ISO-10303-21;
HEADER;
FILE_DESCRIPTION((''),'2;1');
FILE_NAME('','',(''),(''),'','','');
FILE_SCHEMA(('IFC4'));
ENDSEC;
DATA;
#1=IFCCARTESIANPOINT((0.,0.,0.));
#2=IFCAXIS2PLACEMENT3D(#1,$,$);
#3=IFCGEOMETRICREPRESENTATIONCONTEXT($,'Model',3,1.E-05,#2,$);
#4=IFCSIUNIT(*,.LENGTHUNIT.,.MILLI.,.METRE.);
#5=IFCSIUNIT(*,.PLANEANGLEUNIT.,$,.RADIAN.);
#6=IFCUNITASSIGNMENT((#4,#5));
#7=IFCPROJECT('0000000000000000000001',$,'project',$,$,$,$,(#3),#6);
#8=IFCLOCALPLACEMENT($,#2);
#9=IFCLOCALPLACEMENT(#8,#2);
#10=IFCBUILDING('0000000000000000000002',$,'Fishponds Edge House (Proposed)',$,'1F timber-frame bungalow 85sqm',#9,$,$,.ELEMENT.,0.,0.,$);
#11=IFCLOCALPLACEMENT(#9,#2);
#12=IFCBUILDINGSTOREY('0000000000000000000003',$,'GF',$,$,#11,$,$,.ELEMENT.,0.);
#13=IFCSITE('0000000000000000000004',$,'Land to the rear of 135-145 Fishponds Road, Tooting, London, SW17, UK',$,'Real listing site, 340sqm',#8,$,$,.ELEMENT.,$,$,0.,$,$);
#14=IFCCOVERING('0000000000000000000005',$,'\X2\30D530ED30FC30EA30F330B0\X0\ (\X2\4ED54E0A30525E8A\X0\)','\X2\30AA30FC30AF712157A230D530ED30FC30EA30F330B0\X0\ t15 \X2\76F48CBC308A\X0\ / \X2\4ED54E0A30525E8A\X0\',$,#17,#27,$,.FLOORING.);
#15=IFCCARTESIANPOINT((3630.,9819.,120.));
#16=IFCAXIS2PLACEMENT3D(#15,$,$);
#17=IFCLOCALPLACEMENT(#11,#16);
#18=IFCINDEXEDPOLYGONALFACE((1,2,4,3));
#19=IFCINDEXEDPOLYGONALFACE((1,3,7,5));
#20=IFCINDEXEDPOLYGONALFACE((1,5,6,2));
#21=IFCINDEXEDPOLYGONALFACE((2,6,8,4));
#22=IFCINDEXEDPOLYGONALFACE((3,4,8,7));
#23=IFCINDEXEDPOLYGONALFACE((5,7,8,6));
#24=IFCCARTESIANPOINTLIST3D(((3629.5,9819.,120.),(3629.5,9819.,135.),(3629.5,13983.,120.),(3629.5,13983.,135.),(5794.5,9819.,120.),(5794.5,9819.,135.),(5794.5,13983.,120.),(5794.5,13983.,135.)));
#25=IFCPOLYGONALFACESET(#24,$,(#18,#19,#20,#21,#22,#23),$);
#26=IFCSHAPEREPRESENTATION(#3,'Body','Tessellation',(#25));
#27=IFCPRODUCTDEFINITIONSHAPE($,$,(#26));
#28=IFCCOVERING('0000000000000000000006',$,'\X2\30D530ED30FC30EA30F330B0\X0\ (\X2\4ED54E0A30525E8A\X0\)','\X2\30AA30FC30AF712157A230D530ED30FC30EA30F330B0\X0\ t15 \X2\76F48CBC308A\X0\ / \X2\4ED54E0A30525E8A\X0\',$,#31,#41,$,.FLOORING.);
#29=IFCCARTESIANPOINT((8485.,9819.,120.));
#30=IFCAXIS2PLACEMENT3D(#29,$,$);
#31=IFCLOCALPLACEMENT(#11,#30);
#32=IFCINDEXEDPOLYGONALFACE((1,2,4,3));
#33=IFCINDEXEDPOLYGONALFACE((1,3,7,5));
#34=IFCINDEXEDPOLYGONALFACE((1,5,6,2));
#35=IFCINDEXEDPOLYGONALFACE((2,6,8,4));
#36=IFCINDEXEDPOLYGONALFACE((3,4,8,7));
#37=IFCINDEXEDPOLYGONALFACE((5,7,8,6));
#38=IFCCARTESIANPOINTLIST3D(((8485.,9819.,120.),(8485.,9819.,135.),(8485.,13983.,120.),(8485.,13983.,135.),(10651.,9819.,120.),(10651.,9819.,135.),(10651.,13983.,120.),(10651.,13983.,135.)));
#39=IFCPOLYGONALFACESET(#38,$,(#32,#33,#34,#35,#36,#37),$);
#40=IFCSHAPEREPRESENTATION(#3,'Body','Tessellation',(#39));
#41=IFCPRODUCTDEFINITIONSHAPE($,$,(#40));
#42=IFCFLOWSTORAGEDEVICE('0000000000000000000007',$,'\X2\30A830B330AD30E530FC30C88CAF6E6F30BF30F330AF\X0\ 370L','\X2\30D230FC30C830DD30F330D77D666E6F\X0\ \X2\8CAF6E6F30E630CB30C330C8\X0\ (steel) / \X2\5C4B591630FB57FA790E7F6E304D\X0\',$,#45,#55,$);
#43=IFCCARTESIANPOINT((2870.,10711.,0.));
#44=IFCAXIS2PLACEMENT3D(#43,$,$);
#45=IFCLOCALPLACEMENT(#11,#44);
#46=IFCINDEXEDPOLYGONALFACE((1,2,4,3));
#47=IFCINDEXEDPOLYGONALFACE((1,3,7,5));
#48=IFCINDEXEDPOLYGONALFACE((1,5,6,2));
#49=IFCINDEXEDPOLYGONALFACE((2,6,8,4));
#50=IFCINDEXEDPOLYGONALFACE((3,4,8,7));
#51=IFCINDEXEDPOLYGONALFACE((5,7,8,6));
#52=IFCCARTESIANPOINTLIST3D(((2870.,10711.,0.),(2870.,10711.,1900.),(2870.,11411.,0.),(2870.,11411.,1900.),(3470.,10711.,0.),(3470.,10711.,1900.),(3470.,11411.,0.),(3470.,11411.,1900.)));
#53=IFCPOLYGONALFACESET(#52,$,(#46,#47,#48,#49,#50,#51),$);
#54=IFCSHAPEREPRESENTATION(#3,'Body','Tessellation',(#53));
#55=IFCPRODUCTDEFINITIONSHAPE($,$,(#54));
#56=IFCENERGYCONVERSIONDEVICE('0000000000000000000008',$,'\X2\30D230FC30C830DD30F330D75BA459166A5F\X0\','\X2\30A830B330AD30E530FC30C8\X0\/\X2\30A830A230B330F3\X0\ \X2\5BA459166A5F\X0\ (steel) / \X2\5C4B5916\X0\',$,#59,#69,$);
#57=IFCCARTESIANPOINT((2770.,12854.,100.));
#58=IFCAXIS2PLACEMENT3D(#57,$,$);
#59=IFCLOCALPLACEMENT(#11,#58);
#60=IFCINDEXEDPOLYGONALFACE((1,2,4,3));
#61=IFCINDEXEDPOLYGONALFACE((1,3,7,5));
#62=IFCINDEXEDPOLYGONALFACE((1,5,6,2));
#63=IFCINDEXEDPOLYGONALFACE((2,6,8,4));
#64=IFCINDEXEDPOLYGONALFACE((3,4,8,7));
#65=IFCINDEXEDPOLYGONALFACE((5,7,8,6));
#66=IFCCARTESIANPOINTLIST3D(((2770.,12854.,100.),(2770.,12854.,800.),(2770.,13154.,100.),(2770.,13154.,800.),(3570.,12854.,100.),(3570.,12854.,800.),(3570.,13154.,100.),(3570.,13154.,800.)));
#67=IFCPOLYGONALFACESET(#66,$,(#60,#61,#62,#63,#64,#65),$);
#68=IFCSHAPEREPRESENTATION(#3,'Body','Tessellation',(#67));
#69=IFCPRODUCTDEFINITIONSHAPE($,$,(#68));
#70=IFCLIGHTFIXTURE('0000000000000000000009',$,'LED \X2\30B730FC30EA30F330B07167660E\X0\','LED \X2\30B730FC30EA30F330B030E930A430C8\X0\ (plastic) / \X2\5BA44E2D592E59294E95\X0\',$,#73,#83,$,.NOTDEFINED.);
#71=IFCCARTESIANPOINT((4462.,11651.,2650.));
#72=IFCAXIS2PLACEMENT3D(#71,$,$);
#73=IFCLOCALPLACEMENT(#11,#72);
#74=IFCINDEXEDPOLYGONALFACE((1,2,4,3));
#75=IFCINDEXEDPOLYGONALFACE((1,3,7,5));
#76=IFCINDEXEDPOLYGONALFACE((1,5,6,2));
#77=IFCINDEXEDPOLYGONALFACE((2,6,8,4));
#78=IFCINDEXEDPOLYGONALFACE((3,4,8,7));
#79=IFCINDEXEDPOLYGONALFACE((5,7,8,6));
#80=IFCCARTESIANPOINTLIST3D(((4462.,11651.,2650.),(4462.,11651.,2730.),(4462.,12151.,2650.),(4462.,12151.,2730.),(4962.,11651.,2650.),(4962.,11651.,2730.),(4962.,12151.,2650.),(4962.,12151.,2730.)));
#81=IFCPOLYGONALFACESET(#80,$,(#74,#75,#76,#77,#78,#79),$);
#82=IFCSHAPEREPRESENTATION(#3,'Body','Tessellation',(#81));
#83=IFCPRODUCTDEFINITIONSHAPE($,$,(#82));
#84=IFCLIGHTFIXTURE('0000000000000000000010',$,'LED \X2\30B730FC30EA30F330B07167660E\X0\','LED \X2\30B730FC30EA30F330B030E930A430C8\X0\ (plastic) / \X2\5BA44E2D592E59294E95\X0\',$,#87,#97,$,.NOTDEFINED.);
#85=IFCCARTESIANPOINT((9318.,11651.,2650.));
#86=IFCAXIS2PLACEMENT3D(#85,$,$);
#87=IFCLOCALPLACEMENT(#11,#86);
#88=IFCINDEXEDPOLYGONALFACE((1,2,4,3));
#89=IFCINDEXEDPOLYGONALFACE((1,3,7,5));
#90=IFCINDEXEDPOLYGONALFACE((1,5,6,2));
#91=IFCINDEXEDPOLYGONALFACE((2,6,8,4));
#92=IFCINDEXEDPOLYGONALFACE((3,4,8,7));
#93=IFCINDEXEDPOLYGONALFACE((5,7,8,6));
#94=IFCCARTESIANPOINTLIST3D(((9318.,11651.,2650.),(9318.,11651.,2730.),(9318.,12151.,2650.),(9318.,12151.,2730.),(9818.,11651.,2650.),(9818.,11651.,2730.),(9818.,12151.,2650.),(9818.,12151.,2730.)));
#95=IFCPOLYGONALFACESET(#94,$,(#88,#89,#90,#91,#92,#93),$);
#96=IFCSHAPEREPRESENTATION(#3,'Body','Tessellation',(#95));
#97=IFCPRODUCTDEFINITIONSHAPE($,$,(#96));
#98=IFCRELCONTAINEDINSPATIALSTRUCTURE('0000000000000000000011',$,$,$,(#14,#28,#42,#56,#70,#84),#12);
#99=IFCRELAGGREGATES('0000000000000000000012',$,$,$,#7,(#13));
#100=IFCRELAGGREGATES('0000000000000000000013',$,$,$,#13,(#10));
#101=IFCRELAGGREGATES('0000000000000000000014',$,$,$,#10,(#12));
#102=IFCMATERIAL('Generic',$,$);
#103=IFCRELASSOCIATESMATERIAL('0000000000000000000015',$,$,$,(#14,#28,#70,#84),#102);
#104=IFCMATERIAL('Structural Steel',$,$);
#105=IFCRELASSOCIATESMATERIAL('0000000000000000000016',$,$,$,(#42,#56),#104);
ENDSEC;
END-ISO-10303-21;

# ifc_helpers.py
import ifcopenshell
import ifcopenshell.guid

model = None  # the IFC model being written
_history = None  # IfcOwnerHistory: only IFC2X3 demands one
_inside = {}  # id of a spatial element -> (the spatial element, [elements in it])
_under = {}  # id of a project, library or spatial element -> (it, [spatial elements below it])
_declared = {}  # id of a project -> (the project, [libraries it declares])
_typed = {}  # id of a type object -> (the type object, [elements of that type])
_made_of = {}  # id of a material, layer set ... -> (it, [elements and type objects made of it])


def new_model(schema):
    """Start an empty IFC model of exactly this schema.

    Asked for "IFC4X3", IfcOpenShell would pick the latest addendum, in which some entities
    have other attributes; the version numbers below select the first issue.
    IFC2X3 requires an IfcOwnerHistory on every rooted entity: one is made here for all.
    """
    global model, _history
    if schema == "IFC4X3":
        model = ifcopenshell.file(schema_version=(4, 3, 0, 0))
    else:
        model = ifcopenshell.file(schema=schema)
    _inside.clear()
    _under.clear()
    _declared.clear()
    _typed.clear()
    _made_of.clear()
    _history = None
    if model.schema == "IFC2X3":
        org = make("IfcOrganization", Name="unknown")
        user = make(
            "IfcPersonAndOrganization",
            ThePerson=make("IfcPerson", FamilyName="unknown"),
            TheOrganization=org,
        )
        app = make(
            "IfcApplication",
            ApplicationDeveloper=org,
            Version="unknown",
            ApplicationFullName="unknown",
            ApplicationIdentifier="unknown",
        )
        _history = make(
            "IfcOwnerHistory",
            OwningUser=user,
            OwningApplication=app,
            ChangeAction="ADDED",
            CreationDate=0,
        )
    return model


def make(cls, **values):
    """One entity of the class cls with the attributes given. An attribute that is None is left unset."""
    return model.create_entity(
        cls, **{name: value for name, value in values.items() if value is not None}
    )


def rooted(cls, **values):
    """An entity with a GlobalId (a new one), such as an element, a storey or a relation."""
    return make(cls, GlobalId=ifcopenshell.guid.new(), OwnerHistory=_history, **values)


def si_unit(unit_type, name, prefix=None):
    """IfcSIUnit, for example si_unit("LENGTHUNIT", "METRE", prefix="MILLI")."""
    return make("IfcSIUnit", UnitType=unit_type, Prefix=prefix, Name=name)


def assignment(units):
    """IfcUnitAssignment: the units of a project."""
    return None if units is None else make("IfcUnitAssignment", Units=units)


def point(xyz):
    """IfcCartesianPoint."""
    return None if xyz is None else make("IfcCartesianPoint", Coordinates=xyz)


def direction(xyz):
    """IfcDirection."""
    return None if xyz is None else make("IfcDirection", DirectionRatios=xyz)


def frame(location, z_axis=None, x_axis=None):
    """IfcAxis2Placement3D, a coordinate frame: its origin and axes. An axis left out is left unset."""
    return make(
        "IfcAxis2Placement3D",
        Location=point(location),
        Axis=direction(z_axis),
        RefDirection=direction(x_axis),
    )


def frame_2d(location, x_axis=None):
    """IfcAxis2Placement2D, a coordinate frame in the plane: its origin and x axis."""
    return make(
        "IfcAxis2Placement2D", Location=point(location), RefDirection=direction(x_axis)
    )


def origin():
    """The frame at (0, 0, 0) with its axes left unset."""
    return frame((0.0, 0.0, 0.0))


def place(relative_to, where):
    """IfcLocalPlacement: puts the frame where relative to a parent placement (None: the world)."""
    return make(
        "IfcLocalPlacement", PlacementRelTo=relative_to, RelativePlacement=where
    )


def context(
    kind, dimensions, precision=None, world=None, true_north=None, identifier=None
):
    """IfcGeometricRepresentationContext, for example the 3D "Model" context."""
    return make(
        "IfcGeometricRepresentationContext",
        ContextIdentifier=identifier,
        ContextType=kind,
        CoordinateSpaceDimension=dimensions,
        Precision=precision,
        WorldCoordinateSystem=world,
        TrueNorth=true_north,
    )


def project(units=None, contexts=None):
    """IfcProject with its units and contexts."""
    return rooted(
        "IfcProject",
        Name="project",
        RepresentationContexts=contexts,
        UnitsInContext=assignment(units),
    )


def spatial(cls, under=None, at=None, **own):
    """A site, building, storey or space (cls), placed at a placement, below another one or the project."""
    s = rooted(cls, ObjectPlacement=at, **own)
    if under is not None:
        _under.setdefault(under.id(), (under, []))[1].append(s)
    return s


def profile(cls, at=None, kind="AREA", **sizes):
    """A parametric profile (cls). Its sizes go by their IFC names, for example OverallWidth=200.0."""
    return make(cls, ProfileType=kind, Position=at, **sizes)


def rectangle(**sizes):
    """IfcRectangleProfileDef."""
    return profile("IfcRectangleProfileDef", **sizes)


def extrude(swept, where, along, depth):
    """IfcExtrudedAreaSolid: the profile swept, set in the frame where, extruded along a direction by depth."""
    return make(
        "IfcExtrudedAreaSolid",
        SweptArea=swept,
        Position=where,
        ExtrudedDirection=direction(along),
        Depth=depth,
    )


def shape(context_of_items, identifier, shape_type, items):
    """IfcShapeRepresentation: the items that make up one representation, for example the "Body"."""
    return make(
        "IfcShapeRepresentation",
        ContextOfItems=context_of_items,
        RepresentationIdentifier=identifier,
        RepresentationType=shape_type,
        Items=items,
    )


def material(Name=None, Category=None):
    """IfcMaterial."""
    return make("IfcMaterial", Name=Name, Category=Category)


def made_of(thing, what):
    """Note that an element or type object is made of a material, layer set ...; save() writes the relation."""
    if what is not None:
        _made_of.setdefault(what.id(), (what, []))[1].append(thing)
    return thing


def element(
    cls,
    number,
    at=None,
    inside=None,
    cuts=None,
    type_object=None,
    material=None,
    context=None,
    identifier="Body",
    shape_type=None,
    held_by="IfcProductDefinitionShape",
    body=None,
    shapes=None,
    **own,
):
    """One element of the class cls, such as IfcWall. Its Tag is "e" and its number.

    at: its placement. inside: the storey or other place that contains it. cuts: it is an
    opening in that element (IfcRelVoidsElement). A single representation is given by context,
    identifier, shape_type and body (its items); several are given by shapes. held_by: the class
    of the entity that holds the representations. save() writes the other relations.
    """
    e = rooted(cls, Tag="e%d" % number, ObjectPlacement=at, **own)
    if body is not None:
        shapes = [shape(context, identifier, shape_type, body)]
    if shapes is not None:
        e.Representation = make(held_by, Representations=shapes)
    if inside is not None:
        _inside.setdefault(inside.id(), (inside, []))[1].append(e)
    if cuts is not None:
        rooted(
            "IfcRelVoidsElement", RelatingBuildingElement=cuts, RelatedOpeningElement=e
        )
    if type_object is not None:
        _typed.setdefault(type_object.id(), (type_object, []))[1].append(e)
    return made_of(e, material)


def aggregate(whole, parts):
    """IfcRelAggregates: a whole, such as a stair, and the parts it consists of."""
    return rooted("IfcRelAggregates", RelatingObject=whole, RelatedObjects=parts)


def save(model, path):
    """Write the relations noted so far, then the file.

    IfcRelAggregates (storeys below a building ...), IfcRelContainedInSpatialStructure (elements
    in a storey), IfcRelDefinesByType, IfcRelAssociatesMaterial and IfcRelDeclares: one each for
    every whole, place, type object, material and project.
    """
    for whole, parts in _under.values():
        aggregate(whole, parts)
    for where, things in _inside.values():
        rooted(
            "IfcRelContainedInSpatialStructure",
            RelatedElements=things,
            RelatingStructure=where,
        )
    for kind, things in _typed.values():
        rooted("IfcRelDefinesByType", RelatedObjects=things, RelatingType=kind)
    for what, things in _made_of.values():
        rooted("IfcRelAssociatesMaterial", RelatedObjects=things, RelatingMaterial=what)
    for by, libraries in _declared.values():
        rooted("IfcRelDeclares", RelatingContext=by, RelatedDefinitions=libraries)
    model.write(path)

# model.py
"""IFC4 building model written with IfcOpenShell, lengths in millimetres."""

from ifc_helpers import new_model, si_unit, frame, frame_2d, origin, place, context, project, spatial, rectangle, extrude, material, element, save


model = new_model("IFC4")

# Units and contexts
model_context = context("Model", 3, precision=1e-05, world=origin())
ifc_project = project(units=[si_unit("LENGTHUNIT", "METRE", prefix="MILLI"), si_unit("PLANEANGLEUNIT", "RADIAN")], contexts=[model_context])

# Site, building, storey
site_placement = place(None, origin())
site = spatial("IfcSite", under=ifc_project, at=site_placement, Name="Land to the rear of 135-145 Fishponds Road, Tooting, London, SW17, UK", ObjectType="Real listing site, 340sqm", CompositionType="ELEMENT", RefElevation=0.0)
building_placement = place(site_placement, origin())
building = spatial("IfcBuilding", under=site, at=building_placement, Name="Fishponds Edge House (Proposed)", ObjectType="1F timber-frame bungalow 85sqm", CompositionType="ELEMENT", ElevationOfRefHeight=0.0, ElevationOfTerrain=0.0)
storey_placement = place(building_placement, origin())
storey = spatial("IfcBuildingStorey", under=building, at=storey_placement, Name="GF", CompositionType="ELEMENT", Elevation=0.0)

# Shared definitions
ifc_material_1 = material(Name="Structural Steel")

# Coverings
ifc_material_2 = material(Name="Generic")
covering_1_placement = place(storey_placement, frame((3630.0, 9819.0, 120.0)))
element("IfcCovering", 1, at=covering_1_placement, inside=storey, material=ifc_material_2, Name="フローリング (仕上げ床)", Description="オーク無垢フローリング t15 直貼り / 仕上げ床", PredefinedType="FLOORING", context=model_context, shape_type="SweptSolid", body=[
    extrude(rectangle(XDim=2165.0, YDim=4164.0, at=frame_2d((1082.0, 2082.0))), frame((3630.0, 9819.0, 120.0)), (0.0, 0.0, 1.0), 15.0),
])
covering_2_placement = place(storey_placement, frame((8485.0, 9819.0, 120.0)))
element("IfcCovering", 2, at=covering_2_placement, inside=storey, material=ifc_material_2, Name="フローリング (仕上げ床)", Description="オーク無垢フローリング t15 直貼り / 仕上げ床", PredefinedType="FLOORING", context=model_context, shape_type="SweptSolid", body=[
    extrude(rectangle(XDim=2166.0, YDim=4164.0, at=frame_2d((1083.0, 2082.0))), frame((8485.0, 9819.0, 120.0)), (0.0, 0.0, 1.0), 15.0),
])

# Flow storage device
flow_storage_device_placement = place(storey_placement, frame((2870.0, 10711.0, 0.0)))
element("IfcFlowStorageDevice", 3, at=flow_storage_device_placement, inside=storey, material=ifc_material_1, Name="エコキュート貯湯タンク 370L", Description="ヒートポンプ給湯 貯湯ユニット (steel) / 屋外・基礎置き", context=model_context, shape_type="SweptSolid", body=[
    extrude(rectangle(XDim=600.0, YDim=700.0, at=frame_2d((300.0, 350.0))), frame((2870.0, 10711.0, 0.0)), (0.0, 0.0, 1.0), 1900.0),
])

# Energy conversion device
energy_conversion_device_placement = place(storey_placement, frame((2770.0, 12854.0, 100.0)))
element("IfcEnergyConversionDevice", 4, at=energy_conversion_device_placement, inside=storey, material=ifc_material_1, Name="ヒートポンプ室外機", Description="エコキュート/エアコン 室外機 (steel) / 屋外", context=model_context, shape_type="SweptSolid", body=[
    extrude(rectangle(XDim=800.0, YDim=300.0, at=frame_2d((400.0, 150.0))), frame((2770.0, 12854.0, 100.0)), (0.0, 0.0, 1.0), 700.0),
])

# Light fixtures
light_fixture_1_placement = place(storey_placement, frame((4462.0, 11651.0, 2650.0)))
element("IfcLightFixture", 5, at=light_fixture_1_placement, inside=storey, material=ifc_material_2, Name="LED シーリング照明", Description="LED シーリングライト (plastic) / 室中央天井", PredefinedType="NOTDEFINED", context=model_context, shape_type="SweptSolid", body=[
    extrude(rectangle(XDim=500.0, YDim=500.0, at=frame_2d((250.0, 250.0))), frame((4462.0, 11651.0, 2650.0)), (0.0, 0.0, 1.0), 80.0),
])
light_fixture_2_placement = place(storey_placement, frame((9318.0, 11651.0, 2650.0)))
element("IfcLightFixture", 6, at=light_fixture_2_placement, inside=storey, material=ifc_material_2, Name="LED シーリング照明", Description="LED シーリングライト (plastic) / 室中央天井", PredefinedType="NOTDEFINED", context=model_context, shape_type="SweptSolid", body=[
    extrude(rectangle(XDim=500.0, YDim=500.0, at=frame_2d((250.0, 250.0))), frame((9318.0, 11651.0, 2650.0)), (0.0, 0.0, 1.0), 80.0),
])

save(model, "model.ifc")
